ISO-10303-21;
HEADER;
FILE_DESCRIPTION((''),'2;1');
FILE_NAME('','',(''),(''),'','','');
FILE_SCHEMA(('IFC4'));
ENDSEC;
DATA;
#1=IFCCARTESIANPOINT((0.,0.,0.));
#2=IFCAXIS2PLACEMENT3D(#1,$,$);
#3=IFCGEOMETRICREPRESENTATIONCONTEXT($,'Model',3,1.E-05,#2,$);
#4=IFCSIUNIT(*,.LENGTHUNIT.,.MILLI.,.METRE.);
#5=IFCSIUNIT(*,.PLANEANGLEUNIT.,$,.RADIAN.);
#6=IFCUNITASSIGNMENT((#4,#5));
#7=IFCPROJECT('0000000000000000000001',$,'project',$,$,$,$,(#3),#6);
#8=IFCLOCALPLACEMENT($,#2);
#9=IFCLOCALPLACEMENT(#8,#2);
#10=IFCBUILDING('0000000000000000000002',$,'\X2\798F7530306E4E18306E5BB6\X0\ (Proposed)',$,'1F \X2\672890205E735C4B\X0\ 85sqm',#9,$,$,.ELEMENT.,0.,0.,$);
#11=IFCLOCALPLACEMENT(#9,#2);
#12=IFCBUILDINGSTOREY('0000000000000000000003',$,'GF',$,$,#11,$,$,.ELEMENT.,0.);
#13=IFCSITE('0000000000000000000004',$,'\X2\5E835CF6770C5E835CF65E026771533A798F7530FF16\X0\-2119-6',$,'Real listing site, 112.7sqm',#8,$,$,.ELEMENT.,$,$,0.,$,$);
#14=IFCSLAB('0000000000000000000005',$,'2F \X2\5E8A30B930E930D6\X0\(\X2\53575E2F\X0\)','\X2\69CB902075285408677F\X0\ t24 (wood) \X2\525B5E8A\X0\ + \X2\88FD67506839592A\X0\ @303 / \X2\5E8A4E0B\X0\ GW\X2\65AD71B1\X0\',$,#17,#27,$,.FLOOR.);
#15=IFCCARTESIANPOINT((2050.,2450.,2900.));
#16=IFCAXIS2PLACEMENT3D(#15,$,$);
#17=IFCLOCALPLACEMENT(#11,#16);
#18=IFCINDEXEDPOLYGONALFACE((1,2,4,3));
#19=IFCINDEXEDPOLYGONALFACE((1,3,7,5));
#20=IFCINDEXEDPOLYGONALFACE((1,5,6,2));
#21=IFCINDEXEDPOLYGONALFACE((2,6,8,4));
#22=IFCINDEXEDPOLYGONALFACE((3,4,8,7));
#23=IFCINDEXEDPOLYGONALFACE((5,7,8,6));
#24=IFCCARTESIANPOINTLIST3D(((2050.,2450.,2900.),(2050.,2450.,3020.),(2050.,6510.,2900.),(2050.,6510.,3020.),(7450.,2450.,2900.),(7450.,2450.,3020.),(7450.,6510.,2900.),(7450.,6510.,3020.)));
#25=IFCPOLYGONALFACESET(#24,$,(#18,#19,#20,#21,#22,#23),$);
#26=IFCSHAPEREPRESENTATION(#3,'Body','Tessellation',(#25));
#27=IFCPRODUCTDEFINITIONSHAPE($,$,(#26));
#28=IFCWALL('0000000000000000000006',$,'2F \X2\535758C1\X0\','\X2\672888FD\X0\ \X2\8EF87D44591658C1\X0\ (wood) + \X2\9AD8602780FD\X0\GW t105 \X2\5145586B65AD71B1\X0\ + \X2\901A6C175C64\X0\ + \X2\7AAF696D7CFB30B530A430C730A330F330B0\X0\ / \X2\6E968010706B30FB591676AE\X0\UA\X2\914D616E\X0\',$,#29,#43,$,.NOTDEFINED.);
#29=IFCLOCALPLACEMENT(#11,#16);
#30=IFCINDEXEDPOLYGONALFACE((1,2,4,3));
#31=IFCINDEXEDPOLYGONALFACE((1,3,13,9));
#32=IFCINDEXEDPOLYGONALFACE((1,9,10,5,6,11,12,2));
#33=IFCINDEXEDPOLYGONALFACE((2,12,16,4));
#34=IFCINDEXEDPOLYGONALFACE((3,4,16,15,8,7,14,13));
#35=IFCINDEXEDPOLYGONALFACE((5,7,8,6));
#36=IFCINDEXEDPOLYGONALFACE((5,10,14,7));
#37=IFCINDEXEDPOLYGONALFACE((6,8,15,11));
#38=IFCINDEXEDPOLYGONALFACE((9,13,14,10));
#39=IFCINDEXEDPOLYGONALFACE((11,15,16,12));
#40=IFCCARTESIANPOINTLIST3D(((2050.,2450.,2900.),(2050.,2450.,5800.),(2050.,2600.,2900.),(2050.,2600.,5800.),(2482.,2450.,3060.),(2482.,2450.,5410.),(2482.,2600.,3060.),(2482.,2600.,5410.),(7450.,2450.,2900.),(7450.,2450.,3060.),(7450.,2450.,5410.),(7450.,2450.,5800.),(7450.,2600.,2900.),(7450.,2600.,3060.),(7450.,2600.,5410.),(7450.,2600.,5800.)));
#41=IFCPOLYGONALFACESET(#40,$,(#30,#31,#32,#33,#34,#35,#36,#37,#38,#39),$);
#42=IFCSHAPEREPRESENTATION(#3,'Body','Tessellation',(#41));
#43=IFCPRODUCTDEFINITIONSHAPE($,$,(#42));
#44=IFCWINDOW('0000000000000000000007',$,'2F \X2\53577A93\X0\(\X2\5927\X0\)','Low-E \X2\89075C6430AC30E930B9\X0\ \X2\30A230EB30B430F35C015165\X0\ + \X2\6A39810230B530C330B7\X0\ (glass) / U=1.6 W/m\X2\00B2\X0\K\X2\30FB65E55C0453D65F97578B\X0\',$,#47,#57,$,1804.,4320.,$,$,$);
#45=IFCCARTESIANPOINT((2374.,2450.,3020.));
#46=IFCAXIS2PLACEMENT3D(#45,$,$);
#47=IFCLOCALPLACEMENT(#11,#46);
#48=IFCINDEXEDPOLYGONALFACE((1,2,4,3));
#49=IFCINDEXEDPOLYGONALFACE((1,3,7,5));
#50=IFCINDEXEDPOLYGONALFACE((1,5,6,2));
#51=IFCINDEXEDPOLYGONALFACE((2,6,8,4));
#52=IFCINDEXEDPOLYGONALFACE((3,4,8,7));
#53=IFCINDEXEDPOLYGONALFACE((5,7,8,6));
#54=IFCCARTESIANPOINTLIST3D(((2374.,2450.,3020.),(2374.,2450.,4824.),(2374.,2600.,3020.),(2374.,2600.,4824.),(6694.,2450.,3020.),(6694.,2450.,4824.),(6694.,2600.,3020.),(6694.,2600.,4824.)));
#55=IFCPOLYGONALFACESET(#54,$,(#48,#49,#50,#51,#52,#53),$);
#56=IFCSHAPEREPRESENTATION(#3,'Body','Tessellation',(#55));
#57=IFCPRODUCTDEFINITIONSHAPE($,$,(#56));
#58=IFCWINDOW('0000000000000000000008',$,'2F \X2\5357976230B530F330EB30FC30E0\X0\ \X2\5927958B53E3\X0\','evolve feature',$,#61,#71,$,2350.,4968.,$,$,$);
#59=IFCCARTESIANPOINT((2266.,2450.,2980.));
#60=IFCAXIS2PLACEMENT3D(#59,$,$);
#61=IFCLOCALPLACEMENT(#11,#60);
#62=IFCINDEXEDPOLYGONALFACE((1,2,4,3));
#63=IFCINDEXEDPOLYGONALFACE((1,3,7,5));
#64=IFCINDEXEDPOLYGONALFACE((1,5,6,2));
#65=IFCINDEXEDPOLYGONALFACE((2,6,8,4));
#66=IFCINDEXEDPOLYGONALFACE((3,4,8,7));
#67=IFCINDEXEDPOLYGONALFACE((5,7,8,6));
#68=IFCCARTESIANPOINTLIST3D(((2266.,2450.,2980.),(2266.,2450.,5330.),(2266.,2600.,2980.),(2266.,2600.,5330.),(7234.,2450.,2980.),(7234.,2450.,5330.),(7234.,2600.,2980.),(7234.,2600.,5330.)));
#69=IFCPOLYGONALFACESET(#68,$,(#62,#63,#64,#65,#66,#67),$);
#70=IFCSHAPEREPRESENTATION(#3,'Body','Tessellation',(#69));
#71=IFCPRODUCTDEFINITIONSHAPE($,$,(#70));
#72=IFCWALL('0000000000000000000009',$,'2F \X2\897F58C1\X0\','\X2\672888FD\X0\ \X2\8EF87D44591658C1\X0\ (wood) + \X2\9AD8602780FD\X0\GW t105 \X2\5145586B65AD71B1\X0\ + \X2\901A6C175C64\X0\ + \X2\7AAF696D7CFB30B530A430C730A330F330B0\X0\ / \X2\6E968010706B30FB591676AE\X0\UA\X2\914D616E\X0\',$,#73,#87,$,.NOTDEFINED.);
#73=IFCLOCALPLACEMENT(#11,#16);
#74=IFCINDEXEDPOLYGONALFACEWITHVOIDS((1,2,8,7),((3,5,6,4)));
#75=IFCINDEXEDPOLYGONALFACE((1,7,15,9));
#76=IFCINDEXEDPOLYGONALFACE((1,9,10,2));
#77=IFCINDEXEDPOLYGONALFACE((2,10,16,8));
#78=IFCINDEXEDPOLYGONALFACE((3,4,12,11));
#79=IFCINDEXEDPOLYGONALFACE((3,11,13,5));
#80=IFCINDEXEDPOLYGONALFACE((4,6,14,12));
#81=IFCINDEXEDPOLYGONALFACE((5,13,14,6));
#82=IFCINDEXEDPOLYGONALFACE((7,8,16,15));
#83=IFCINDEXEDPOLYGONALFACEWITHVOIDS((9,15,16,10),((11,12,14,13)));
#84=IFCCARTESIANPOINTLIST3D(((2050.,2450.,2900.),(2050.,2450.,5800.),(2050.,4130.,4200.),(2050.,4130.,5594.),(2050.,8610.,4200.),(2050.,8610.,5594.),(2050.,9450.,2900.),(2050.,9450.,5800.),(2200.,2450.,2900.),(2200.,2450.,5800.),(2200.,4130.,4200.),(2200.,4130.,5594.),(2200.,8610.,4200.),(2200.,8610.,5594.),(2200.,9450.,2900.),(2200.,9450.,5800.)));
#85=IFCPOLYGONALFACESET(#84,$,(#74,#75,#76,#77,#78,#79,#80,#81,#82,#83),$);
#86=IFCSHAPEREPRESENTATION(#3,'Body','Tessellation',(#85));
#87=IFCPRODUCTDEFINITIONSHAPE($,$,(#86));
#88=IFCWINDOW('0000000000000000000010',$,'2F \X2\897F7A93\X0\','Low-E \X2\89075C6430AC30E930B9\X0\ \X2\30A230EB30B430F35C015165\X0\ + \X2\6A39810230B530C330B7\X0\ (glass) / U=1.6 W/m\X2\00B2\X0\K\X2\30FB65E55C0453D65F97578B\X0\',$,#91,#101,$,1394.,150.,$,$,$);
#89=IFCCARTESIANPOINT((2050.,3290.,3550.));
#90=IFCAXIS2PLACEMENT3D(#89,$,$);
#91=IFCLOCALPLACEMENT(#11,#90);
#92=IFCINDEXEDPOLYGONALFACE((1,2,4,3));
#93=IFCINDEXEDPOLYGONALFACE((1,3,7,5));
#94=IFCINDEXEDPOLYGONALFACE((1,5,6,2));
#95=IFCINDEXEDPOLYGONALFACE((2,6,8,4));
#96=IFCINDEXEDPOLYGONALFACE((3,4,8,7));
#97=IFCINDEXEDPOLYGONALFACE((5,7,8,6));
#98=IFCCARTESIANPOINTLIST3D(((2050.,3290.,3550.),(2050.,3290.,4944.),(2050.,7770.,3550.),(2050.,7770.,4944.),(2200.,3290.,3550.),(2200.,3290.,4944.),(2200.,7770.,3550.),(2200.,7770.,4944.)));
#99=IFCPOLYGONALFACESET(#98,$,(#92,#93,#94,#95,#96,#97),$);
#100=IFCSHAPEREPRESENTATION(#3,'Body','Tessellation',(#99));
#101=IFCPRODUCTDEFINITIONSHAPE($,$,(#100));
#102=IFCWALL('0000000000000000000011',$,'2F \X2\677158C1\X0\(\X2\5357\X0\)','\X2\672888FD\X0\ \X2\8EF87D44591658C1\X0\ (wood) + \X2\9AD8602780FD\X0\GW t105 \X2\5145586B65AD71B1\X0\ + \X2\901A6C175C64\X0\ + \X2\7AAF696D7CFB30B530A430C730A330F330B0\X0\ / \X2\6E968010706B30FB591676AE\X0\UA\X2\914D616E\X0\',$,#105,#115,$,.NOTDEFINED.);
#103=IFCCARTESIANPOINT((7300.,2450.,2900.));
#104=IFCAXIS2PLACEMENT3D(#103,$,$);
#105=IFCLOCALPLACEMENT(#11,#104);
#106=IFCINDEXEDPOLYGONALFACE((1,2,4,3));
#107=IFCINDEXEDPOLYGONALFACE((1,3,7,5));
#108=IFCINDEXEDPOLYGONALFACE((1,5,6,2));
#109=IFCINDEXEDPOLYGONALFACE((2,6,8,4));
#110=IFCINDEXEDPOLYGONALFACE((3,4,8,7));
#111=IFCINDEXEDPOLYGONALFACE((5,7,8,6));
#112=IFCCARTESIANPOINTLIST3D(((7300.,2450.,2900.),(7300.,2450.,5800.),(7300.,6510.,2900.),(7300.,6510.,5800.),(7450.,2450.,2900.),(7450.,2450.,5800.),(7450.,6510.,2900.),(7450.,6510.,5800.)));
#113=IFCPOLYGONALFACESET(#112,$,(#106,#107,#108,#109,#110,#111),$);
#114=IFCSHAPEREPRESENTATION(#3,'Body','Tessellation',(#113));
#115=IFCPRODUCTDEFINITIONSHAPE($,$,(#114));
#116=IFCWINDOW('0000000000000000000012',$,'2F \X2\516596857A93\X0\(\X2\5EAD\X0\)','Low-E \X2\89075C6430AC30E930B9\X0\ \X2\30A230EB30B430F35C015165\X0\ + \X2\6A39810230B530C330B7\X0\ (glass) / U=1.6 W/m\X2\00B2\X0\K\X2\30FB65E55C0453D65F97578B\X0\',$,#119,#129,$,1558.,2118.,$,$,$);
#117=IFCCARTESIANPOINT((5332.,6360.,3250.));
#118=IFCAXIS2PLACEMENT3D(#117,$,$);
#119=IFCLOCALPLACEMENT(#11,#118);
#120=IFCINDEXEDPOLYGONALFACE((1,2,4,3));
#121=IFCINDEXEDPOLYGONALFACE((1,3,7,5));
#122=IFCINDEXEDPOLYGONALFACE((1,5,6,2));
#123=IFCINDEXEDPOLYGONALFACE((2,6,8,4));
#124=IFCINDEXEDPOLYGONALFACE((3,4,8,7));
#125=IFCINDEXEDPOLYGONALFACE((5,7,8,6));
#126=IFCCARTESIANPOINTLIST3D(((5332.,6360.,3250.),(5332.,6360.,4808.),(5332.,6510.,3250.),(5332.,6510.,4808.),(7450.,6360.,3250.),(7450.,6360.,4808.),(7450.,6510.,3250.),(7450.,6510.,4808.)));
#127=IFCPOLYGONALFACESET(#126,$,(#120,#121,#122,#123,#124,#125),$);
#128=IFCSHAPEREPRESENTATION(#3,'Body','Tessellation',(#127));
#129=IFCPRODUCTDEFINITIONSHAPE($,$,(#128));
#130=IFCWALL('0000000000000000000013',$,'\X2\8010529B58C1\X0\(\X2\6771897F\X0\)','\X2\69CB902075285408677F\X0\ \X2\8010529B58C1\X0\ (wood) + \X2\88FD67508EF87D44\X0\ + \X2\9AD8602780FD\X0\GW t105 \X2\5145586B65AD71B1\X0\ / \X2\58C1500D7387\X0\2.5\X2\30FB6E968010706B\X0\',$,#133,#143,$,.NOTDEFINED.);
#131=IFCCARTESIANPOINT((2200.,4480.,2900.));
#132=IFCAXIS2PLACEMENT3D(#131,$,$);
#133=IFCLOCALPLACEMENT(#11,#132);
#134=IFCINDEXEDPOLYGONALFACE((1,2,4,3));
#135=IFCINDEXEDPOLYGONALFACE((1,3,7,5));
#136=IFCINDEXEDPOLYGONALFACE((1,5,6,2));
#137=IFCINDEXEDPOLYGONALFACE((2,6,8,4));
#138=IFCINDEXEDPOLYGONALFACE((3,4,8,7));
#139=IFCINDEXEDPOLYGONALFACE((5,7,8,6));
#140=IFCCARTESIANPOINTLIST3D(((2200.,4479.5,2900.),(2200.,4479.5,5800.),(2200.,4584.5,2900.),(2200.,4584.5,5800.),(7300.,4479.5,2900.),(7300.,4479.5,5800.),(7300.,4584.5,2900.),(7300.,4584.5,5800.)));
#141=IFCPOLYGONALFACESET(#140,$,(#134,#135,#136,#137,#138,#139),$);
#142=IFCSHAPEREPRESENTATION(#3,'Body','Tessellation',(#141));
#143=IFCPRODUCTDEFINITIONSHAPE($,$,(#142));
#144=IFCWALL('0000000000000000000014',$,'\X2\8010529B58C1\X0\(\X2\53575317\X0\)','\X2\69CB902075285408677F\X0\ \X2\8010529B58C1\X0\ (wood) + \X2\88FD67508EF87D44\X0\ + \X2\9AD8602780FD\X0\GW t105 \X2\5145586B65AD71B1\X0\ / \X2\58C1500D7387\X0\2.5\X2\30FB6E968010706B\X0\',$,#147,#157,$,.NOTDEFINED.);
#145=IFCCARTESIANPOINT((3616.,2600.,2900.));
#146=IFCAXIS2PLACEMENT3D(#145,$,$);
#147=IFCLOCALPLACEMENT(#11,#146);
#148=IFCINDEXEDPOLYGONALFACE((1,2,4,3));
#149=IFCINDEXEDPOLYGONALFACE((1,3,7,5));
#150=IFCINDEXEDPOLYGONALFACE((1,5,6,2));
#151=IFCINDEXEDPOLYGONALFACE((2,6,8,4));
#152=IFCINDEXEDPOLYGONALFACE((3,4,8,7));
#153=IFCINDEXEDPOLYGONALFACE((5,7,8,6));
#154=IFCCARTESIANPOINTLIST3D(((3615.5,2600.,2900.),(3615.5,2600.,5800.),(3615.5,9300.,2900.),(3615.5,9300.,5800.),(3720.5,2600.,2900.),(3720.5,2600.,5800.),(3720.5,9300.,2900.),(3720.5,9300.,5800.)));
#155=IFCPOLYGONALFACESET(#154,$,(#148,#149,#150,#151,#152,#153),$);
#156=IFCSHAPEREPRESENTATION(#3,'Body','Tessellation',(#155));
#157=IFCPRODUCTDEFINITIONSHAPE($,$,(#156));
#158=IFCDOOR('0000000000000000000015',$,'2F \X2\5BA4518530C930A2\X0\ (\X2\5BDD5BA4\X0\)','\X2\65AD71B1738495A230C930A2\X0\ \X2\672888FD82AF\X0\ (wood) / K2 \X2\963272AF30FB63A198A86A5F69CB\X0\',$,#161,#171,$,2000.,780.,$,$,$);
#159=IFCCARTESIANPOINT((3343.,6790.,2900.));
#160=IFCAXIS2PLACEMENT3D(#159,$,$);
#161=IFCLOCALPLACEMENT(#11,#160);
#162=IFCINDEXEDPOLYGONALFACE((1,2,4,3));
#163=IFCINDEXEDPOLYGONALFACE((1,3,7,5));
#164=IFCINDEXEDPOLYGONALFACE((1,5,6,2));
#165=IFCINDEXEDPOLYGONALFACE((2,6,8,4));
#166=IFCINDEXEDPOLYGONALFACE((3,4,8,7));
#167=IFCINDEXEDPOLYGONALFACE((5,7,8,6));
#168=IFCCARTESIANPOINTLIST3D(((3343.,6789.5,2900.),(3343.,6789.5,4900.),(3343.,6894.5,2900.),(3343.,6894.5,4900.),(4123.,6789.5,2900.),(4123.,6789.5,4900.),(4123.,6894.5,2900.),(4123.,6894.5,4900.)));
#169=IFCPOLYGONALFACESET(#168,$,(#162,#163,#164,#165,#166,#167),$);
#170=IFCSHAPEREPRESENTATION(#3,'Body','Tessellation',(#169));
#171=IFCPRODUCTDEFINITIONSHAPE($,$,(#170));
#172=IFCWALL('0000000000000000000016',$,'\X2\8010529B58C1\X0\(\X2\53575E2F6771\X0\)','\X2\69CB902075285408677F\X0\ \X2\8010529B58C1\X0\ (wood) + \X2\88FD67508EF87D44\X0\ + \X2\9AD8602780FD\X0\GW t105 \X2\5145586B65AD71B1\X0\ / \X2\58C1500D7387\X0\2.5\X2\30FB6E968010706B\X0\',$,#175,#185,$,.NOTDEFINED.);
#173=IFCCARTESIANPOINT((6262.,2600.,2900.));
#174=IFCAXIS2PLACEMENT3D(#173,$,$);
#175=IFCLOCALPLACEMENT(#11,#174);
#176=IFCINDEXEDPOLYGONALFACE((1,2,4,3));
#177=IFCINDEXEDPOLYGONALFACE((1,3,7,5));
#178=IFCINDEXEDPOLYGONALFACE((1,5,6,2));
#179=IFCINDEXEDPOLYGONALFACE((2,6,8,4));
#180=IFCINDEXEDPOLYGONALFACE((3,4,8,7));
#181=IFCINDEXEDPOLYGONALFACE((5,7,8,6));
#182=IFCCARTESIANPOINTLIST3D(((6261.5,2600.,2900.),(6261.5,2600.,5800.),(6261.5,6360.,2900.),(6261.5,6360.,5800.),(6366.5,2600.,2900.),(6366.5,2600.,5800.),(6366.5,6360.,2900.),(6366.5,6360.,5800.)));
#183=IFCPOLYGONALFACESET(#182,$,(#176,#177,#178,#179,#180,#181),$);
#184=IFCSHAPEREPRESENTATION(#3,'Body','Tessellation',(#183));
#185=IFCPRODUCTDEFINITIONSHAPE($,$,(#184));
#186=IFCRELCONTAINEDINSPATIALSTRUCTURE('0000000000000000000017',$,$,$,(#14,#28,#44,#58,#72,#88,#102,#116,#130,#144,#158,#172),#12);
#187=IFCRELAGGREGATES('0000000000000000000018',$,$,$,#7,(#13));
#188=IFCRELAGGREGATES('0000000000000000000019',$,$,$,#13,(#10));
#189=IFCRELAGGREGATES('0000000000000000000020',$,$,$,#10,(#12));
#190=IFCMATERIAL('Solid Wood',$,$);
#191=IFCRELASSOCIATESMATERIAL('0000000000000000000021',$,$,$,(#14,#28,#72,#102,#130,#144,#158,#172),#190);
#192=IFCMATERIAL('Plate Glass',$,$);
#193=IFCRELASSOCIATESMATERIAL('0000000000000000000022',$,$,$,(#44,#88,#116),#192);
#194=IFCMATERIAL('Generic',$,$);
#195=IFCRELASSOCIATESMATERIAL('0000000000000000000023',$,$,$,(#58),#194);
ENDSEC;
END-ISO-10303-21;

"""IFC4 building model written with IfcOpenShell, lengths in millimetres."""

from ifc_helpers import new_model, si_unit, frame, frame_2d, origin, place, context, project, spatial, rectangle, extrude, material, element, fill, save


model = new_model("IFC4")

# Units and contexts
model_context = context("Model", 3, precision=1e-05, world=origin())
ifc_project = project(units=[si_unit("LENGTHUNIT", "METRE", prefix="MILLI"), si_unit("PLANEANGLEUNIT", "RADIAN")], contexts=[model_context])

# Site, building, storey
site_placement = place(None, origin())
site = spatial("IfcSite", under=ifc_project, at=site_placement, Name="広島県広島市東区福田６-2119-6", ObjectType="Real listing site, 112.7sqm", CompositionType="ELEMENT", RefElevation=0.0)
building_placement = place(site_placement, origin())
building = spatial("IfcBuilding", under=site, at=building_placement, Name="福田の丘の家 (Proposed)", ObjectType="1F 木造平屋 85sqm", CompositionType="ELEMENT", ElevationOfRefHeight=0.0, ElevationOfTerrain=0.0)
storey_placement = place(building_placement, origin())
storey = spatial("IfcBuildingStorey", under=building, at=storey_placement, Name="GF", CompositionType="ELEMENT", Elevation=0.0)

# Slab
ifc_material_1 = material(Name="Solid Wood")
slab_placement = place(storey_placement, frame((2050.0, 2450.0, 2900.0)))
element("IfcSlab", 1, at=slab_placement, inside=storey, material=ifc_material_1, Name="2F 床スラブ(南帯)", Description="構造用合板 t24 (wood) 剛床 + 製材根太 @303 / 床下 GW断熱", PredefinedType="FLOOR", context=model_context, shape_type="SweptSolid", body=[
    extrude(rectangle(XDim=5400.0, YDim=4060.0, at=frame_2d((2700.0, 2030.0))), frame((2050.0, 2450.0, 2900.0)), (0.0, 0.0, 1.0), 120.0),
])

# Wall, openings, windows
wall_1_placement = place(storey_placement, frame((2050.0, 2450.0, 2900.0)))
wall_1 = element("IfcWall", 2, at=wall_1_placement, inside=storey, material=ifc_material_1, Name="2F 南壁", Description="木製 軸組外壁 (wood) + 高性能GW t105 充填断熱 + 通気層 + 窯業系サイディング / 準耐火・外皮UA配慮", PredefinedType="NOTDEFINED", context=model_context, shape_type="SweptSolid", body=[
    extrude(rectangle(XDim=5400.0, YDim=150.0, at=frame_2d((2700.0, 75.0))), frame((2050.0, 2450.0, 2900.0)), (0.0, 0.0, 1.0), 2900.0),
])
opening_1_placement = place(storey_placement, frame((2374.0, 2450.0, 3020.0)))
opening_1 = element("IfcOpeningElement", 3, at=opening_1_placement, cuts=wall_1, PredefinedType="NOTDEFINED", context=model_context, shape_type="SweptSolid", body=[
    extrude(rectangle(XDim=4320.0, YDim=150.0, at=frame_2d((2160.0, 75.0))), frame((2374.0, 2450.0, 3020.0)), (0.0, 0.0, 1.0), 1804.0),
])
opening_2_placement = place(storey_placement, frame((2266.0, 2450.0, 2980.0)))
opening_2 = element("IfcOpeningElement", 4, at=opening_2_placement, cuts=wall_1, PredefinedType="NOTDEFINED", context=model_context, shape_type="SweptSolid", body=[
    extrude(rectangle(XDim=4968.0, YDim=150.0, at=frame_2d((2484.0, 75.0))), frame((2266.0, 2450.0, 2980.0)), (0.0, 0.0, 1.0), 2350.0),
])
ifc_material_2 = material(Name="Plate Glass")
window_1_placement = place(storey_placement, frame((2374.0, 2450.0, 3020.0)))
window_1 = element("IfcWindow", 5, at=window_1_placement, inside=storey, material=ifc_material_2, Name="2F 南窓(大)", Description="Low-E 複層ガラス アルゴン封入 + 樹脂サッシ (glass) / U=1.6 W/m²K・日射取得型", OverallHeight=1804.0, OverallWidth=4320.0, context=model_context, shape_type="SweptSolid", body=[
    extrude(rectangle(XDim=4320.0, YDim=150.0, at=frame_2d((2160.0, 75.0))), frame((2374.0, 2450.0, 3020.0)), (0.0, 0.0, 1.0), 1804.0),
])
fill(opening_1, window_1)
ifc_material_3 = material(Name="Generic")
window_2_placement = place(storey_placement, frame((2266.0, 2450.0, 2980.0)))
window_2 = element("IfcWindow", 6, at=window_2_placement, inside=storey, material=ifc_material_3, Name="2F 南面サンルーム 大開口", Description="evolve feature", OverallHeight=2350.0, OverallWidth=4968.0, context=model_context, shape_type="SweptSolid", body=[
    extrude(rectangle(XDim=4968.0, YDim=150.0, at=frame_2d((2484.0, 75.0))), frame((2266.0, 2450.0, 2980.0)), (0.0, 0.0, 1.0), 2350.0),
])
fill(opening_2, window_2)

# Walls, openings, windows
wall_2_placement = place(storey_placement, frame((2050.0, 2450.0, 2900.0)))
wall_2 = element("IfcWall", 7, at=wall_2_placement, inside=storey, material=ifc_material_1, Name="2F 西壁", Description="木製 軸組外壁 (wood) + 高性能GW t105 充填断熱 + 通気層 + 窯業系サイディング / 準耐火・外皮UA配慮", PredefinedType="NOTDEFINED", context=model_context, shape_type="SweptSolid", body=[
    extrude(rectangle(XDim=150.0, YDim=7000.0, at=frame_2d((75.0, 3500.0))), frame((2050.0, 2450.0, 2900.0)), (0.0, 0.0, 1.0), 2900.0),
])
opening_3_placement = place(storey_placement, frame((2050.0, 3290.0, 3550.0)))
opening_3 = element("IfcOpeningElement", 8, at=opening_3_placement, cuts=wall_2, PredefinedType="NOTDEFINED", context=model_context, shape_type="SweptSolid", body=[
    extrude(rectangle(XDim=150.0, YDim=4480.0, at=frame_2d((75.0, 2240.0))), frame((2050.0, 3290.0, 3550.0)), (0.0, 0.0, 1.0), 1394.0),
])
window_3_placement = place(storey_placement, frame((2050.0, 3290.0, 3550.0)))
window_3 = element("IfcWindow", 9, at=window_3_placement, inside=storey, material=ifc_material_2, Name="2F 西窓", Description="Low-E 複層ガラス アルゴン封入 + 樹脂サッシ (glass) / U=1.6 W/m²K・日射取得型", OverallHeight=1394.0, OverallWidth=150.0, context=model_context, shape_type="SweptSolid", body=[
    extrude(rectangle(XDim=150.0, YDim=4480.0, at=frame_2d((75.0, 2240.0))), frame((2050.0, 3290.0, 3550.0)), (0.0, 0.0, 1.0), 1394.0),
])
fill(opening_3, window_3)
wall_3_placement = place(storey_placement, frame((7300.0, 2450.0, 2900.0)))
wall_3 = element("IfcWall", 10, at=wall_3_placement, inside=storey, material=ifc_material_1, Name="2F 東壁(南)", Description="木製 軸組外壁 (wood) + 高性能GW t105 充填断熱 + 通気層 + 窯業系サイディング / 準耐火・外皮UA配慮", PredefinedType="NOTDEFINED", context=model_context, shape_type="SweptSolid", body=[
    extrude(rectangle(XDim=150.0, YDim=4060.0, at=frame_2d((75.0, 2030.0))), frame((7300.0, 2450.0, 2900.0)), (0.0, 0.0, 1.0), 2900.0),
])
opening_4_placement = place(storey_placement, frame((5332.0, 6360.0, 3250.0)))
opening_4 = element("IfcOpeningElement", 11, at=opening_4_placement, cuts=wall_3, PredefinedType="NOTDEFINED", context=model_context, shape_type="SweptSolid", body=[
    extrude(rectangle(XDim=2118.0, YDim=150.0, at=frame_2d((1059.0, 75.0))), frame((5332.0, 6360.0, 3250.0)), (0.0, 0.0, 1.0), 1558.0),
])
window_4_placement = place(storey_placement, frame((5332.0, 6360.0, 3250.0)))
window_4 = element("IfcWindow", 12, at=window_4_placement, inside=storey, material=ifc_material_2, Name="2F 入隅窓(庭)", Description="Low-E 複層ガラス アルゴン封入 + 樹脂サッシ (glass) / U=1.6 W/m²K・日射取得型", OverallHeight=1558.0, OverallWidth=2118.0, context=model_context, shape_type="SweptSolid", body=[
    extrude(rectangle(XDim=2118.0, YDim=150.0, at=frame_2d((1059.0, 75.0))), frame((5332.0, 6360.0, 3250.0)), (0.0, 0.0, 1.0), 1558.0),
])
fill(opening_4, window_4)

# Wall
wall_4_placement = place(storey_placement, frame((2200.0, 4480.0, 2900.0)))
element("IfcWall", 13, at=wall_4_placement, inside=storey, material=ifc_material_1, Name="耐力壁(東西)", Description="構造用合板 耐力壁 (wood) + 製材軸組 + 高性能GW t105 充填断熱 / 壁倍率2.5・準耐火", PredefinedType="NOTDEFINED", context=model_context, shape_type="SweptSolid", body=[
    extrude(rectangle(XDim=5100.0, YDim=105.0, at=frame_2d((2550.0, 52.0))), frame((2200.0, 4480.0, 2900.0)), (0.0, 0.0, 1.0), 2900.0),
])

# Wall, opening, door
wall_5_placement = place(storey_placement, frame((3616.0, 2600.0, 2900.0)))
wall_5 = element("IfcWall", 14, at=wall_5_placement, inside=storey, material=ifc_material_1, Name="耐力壁(南北)", Description="構造用合板 耐力壁 (wood) + 製材軸組 + 高性能GW t105 充填断熱 / 壁倍率2.5・準耐火", PredefinedType="NOTDEFINED", context=model_context, shape_type="SweptSolid", body=[
    extrude(rectangle(XDim=105.0, YDim=6700.0, at=frame_2d((52.0, 3350.0))), frame((3616.0, 2600.0, 2900.0)), (0.0, 0.0, 1.0), 2900.0),
])
opening_5_placement = place(storey_placement, frame((3343.0, 6790.0, 2900.0)))
opening_5 = element("IfcOpeningElement", 15, at=opening_5_placement, cuts=wall_5, PredefinedType="NOTDEFINED", context=model_context, shape_type="SweptSolid", body=[
    extrude(rectangle(XDim=780.0, YDim=105.0, at=frame_2d((390.0, 52.0))), frame((3343.0, 6790.0, 2900.0)), (0.0, 0.0, 1.0), 2000.0),
])
door_placement = place(storey_placement, frame((3343.0, 6790.0, 2900.0)))
door = element("IfcDoor", 16, at=door_placement, inside=storey, material=ifc_material_1, Name="2F 室内ドア (寝室)", Description="断熱玄関ドア 木製芯 (wood) / K2 防犯・採風機構", OverallHeight=2000.0, OverallWidth=780.0, context=model_context, shape_type="SweptSolid", body=[
    extrude(rectangle(XDim=780.0, YDim=105.0, at=frame_2d((390.0, 52.0))), frame((3343.0, 6790.0, 2900.0)), (0.0, 0.0, 1.0), 2000.0),
])
fill(opening_5, door)

# Wall
wall_6_placement = place(storey_placement, frame((6262.0, 2600.0, 2900.0)))
element("IfcWall", 17, at=wall_6_placement, inside=storey, material=ifc_material_1, Name="耐力壁(南帯東)", Description="構造用合板 耐力壁 (wood) + 製材軸組 + 高性能GW t105 充填断熱 / 壁倍率2.5・準耐火", PredefinedType="NOTDEFINED", context=model_context, shape_type="SweptSolid", body=[
    extrude(rectangle(XDim=105.0, YDim=3760.0, at=frame_2d((52.0, 1880.0))), frame((6262.0, 2600.0, 2900.0)), (0.0, 0.0, 1.0), 2900.0),
])

save(model, "model.ifc")
